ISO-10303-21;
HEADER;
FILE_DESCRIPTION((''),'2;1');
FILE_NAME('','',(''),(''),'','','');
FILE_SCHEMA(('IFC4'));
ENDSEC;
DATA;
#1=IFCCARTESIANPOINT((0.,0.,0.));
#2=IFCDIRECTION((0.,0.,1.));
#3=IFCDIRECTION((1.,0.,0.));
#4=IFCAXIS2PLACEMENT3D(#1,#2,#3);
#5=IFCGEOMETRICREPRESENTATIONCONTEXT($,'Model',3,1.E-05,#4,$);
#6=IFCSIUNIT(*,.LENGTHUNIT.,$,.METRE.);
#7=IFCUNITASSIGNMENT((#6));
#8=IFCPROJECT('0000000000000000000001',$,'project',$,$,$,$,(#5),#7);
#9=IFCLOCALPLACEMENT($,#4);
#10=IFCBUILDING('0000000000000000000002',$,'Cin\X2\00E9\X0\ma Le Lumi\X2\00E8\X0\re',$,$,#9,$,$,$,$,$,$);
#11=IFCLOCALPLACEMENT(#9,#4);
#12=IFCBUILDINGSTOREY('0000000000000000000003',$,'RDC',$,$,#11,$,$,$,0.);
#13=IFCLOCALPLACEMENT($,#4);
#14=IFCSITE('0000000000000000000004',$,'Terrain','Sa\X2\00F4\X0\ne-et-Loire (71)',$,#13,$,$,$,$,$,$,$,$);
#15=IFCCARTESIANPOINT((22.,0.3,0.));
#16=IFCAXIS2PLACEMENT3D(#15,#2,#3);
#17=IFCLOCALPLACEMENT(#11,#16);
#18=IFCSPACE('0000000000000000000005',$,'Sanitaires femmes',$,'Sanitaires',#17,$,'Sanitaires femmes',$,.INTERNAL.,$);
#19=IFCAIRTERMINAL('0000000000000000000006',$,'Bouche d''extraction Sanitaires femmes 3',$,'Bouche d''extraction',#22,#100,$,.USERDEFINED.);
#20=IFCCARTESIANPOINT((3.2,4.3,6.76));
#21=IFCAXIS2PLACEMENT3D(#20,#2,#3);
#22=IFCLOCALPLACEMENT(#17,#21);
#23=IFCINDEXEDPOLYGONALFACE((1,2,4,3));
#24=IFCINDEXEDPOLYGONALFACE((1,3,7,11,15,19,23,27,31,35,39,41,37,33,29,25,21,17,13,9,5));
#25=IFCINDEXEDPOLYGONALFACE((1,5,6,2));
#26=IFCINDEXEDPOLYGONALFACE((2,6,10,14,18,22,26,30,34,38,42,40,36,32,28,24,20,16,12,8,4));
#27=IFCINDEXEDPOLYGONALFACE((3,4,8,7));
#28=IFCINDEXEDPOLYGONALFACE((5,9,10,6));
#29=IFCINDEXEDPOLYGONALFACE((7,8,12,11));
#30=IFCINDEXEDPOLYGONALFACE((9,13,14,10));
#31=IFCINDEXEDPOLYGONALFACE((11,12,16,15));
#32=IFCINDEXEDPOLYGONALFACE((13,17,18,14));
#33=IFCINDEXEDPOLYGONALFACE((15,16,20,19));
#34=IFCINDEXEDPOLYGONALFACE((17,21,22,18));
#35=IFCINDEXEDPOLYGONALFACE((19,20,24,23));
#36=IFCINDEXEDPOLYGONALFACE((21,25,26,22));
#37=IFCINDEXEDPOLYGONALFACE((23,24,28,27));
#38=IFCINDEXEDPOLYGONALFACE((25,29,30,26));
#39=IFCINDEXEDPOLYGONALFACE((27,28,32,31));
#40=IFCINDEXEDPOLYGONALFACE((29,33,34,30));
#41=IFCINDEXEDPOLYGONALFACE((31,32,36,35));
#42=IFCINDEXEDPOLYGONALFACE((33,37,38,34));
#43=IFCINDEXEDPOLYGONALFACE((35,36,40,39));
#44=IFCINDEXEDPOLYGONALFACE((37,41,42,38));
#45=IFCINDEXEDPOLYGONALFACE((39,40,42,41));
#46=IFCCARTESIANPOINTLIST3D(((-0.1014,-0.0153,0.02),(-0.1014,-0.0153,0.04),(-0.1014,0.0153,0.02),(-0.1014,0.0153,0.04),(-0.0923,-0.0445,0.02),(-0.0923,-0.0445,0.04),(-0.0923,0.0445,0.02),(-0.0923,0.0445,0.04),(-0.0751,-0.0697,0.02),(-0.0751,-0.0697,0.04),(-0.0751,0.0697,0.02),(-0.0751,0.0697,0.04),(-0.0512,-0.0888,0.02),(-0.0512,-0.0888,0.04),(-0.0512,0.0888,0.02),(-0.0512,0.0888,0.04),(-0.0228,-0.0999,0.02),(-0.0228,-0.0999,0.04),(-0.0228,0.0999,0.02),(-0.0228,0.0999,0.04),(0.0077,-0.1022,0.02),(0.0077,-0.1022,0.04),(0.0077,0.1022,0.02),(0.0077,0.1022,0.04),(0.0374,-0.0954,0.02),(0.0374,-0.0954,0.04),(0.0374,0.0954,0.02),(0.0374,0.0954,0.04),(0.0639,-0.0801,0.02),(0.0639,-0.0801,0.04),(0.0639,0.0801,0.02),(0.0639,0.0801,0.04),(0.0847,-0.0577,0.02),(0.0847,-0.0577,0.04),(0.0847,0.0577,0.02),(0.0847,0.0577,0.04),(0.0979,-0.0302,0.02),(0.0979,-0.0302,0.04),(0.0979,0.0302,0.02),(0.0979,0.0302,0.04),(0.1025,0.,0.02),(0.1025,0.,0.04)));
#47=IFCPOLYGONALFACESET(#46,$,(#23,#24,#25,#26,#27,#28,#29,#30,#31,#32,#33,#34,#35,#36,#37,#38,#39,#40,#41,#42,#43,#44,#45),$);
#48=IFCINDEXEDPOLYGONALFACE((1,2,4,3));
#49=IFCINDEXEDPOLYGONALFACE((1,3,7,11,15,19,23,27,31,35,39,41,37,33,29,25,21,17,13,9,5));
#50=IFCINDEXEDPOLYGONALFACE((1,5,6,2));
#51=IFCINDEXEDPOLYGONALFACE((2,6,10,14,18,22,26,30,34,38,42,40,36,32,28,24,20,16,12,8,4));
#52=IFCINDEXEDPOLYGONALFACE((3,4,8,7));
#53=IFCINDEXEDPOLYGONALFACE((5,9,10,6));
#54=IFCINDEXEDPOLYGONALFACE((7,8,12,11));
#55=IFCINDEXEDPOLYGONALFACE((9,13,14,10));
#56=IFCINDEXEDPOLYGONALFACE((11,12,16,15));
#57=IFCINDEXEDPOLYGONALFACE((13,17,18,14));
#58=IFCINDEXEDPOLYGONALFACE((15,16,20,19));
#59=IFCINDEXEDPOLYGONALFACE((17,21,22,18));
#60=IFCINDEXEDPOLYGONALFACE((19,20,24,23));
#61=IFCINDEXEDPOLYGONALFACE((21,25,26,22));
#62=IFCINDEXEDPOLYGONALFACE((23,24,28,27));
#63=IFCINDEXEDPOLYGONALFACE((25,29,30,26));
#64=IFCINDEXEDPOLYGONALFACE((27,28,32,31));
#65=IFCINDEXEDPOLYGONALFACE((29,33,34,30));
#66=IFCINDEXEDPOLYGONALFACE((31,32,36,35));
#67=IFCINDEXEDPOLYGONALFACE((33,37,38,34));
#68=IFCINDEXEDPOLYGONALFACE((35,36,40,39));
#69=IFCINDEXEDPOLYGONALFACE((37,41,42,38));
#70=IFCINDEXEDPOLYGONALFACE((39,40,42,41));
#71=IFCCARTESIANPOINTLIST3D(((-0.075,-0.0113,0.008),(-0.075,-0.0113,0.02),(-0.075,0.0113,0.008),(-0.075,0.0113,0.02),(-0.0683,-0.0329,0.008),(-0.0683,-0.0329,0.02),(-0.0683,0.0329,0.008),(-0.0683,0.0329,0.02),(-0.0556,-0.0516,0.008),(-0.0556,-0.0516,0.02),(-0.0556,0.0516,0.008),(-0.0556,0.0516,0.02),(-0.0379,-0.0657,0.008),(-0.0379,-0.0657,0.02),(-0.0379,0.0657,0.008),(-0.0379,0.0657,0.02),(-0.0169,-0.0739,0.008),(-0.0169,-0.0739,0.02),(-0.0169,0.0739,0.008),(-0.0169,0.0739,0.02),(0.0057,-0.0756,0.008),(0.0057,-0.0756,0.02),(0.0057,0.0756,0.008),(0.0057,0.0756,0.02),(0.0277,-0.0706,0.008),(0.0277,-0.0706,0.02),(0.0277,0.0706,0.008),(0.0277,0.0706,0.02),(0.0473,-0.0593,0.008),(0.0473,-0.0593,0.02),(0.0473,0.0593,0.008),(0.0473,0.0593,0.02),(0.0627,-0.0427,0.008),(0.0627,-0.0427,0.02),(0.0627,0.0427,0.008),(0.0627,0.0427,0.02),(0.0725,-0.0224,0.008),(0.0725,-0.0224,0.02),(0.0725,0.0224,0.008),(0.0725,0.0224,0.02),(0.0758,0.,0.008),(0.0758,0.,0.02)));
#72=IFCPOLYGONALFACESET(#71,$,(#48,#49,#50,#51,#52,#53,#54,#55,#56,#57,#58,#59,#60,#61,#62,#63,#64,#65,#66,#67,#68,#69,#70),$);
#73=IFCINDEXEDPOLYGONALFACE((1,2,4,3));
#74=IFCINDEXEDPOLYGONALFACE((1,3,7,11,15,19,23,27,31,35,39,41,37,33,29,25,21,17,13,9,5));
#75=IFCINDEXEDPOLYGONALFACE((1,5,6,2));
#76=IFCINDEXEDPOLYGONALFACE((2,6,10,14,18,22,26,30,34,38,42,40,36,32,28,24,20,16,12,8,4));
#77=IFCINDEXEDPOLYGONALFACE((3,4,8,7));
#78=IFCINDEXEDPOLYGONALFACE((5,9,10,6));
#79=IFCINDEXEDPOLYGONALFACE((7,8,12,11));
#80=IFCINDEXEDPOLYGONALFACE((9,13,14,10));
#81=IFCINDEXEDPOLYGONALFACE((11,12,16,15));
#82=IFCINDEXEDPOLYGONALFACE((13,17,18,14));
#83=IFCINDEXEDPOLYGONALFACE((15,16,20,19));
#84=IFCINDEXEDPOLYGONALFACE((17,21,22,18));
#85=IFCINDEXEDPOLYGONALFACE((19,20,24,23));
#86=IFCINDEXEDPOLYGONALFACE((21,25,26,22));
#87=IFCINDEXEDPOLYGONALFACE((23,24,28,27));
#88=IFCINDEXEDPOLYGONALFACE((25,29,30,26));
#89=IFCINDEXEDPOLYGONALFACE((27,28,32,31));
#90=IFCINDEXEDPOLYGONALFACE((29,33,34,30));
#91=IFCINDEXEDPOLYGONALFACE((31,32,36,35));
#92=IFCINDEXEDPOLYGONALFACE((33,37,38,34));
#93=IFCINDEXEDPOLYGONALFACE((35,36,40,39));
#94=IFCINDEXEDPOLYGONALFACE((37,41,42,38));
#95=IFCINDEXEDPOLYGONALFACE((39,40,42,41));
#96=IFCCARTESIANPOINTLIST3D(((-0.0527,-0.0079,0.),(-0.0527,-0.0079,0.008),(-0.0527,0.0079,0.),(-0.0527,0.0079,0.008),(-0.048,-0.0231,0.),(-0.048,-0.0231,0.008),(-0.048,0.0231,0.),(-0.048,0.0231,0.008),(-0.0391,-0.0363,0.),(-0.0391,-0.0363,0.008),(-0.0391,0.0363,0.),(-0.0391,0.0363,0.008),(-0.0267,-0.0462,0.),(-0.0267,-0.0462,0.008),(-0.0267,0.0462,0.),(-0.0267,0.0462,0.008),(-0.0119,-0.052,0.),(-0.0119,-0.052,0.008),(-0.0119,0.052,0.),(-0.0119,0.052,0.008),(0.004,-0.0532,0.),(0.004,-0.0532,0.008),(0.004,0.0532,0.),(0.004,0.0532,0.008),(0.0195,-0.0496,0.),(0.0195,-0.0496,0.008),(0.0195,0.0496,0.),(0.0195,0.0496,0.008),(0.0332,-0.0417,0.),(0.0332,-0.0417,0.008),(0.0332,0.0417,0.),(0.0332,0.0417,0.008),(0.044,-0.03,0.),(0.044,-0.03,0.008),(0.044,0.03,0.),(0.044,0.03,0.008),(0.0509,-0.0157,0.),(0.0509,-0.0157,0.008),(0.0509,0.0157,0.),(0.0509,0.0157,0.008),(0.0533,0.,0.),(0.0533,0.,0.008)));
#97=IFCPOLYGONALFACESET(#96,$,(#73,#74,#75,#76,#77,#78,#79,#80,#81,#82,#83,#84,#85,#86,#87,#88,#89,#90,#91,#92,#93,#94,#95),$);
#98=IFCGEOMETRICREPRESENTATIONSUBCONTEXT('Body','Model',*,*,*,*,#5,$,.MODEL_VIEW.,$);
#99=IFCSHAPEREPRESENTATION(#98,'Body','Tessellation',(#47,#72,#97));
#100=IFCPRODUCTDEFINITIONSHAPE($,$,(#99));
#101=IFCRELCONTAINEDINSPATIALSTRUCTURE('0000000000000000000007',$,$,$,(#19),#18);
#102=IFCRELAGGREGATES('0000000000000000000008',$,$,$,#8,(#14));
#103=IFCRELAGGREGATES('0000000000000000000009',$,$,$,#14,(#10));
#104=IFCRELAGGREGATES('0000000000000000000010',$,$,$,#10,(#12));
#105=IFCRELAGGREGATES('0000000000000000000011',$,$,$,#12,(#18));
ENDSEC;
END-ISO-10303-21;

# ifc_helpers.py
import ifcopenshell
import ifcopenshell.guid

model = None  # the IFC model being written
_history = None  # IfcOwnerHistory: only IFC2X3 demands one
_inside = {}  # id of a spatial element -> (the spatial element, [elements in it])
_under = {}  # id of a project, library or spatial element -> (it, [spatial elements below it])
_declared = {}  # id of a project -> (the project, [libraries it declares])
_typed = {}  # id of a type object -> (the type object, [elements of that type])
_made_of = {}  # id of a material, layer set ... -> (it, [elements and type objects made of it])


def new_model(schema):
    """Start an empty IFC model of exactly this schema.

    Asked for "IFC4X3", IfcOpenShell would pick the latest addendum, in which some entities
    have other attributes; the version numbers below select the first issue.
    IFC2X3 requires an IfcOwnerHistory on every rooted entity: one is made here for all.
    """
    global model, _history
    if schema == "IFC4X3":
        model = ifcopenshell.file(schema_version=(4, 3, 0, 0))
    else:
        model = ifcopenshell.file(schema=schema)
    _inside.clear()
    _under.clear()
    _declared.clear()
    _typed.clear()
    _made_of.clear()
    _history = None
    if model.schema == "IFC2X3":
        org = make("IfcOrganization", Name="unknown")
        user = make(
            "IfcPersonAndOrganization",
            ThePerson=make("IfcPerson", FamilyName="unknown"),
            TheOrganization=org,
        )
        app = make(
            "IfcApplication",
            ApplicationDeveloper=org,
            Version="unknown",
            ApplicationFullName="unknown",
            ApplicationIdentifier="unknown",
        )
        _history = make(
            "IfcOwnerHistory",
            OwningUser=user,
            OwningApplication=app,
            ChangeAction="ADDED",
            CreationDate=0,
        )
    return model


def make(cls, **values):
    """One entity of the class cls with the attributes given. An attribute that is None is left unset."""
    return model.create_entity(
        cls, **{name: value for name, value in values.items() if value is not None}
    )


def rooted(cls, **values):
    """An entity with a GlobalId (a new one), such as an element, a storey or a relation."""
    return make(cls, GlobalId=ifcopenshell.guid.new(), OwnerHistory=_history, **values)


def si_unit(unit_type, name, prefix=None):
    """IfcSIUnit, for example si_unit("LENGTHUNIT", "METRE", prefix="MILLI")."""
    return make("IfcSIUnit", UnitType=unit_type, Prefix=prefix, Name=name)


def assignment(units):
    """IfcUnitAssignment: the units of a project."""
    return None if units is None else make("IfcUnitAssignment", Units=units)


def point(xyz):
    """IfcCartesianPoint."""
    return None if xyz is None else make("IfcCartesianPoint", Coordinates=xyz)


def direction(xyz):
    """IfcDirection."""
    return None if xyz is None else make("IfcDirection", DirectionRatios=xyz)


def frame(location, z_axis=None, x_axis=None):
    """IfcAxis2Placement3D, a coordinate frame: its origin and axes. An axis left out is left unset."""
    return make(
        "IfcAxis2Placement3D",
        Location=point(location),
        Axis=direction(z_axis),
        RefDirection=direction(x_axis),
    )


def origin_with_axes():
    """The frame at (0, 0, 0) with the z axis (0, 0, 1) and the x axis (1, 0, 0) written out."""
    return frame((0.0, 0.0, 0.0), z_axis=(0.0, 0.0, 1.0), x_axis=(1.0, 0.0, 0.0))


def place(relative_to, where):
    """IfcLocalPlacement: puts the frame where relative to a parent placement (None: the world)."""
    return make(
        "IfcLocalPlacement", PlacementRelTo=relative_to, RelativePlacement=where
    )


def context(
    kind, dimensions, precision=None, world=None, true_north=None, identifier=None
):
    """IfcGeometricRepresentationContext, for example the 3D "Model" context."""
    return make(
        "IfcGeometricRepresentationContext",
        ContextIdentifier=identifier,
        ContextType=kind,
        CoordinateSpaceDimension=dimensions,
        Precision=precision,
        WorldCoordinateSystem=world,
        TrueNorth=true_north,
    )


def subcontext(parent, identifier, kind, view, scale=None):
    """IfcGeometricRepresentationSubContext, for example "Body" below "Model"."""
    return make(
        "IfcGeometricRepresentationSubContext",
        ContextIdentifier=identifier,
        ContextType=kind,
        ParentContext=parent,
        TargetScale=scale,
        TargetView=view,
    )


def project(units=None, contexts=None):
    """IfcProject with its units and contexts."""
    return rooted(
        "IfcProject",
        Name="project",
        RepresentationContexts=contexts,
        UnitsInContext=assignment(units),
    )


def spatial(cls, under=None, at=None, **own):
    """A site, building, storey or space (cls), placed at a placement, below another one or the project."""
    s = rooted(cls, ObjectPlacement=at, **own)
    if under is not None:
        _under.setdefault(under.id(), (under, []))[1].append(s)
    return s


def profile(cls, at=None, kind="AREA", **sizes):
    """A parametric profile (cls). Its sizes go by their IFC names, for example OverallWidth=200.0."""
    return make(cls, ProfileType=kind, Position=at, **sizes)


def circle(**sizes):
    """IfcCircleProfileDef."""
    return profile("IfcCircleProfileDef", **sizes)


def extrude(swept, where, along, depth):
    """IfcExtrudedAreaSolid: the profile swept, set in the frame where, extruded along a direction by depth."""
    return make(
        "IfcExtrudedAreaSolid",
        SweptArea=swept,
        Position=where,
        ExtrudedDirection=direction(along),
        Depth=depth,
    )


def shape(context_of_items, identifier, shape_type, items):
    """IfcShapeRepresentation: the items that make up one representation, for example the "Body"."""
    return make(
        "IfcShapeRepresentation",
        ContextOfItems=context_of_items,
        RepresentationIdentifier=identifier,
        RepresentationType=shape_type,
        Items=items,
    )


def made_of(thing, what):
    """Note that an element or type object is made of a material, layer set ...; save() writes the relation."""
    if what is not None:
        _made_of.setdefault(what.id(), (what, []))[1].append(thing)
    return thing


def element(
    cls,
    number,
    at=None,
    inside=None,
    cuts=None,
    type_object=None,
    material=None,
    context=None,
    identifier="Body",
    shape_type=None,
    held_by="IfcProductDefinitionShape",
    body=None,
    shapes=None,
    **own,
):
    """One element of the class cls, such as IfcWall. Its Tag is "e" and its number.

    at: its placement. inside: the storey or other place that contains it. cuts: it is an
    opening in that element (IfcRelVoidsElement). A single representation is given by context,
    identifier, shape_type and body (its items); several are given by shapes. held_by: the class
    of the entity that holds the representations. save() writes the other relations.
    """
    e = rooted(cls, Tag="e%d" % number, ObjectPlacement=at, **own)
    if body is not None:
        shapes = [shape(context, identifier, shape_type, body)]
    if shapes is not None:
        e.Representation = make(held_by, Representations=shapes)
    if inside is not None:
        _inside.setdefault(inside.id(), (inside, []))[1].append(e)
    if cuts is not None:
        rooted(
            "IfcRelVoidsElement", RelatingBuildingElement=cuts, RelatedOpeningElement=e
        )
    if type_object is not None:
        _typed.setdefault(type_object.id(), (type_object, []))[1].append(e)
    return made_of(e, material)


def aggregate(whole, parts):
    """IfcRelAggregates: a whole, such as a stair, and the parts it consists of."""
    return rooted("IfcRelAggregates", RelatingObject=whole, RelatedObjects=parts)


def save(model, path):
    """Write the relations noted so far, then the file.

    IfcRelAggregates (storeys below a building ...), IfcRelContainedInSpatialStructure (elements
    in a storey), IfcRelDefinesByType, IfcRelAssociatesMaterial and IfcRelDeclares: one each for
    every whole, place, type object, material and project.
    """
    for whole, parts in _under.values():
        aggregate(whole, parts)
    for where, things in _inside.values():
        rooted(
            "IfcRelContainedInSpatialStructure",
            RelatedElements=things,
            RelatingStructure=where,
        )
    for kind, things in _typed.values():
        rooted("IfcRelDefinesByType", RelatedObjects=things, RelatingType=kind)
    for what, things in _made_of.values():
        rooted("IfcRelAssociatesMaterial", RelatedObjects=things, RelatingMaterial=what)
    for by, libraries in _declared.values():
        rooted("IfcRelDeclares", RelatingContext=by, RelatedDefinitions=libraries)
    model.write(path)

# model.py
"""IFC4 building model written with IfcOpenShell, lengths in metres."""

from ifc_helpers import new_model, si_unit, frame, origin_with_axes, place, context, subcontext, project, spatial, circle, extrude, element, save


model = new_model("IFC4")

# Units and contexts
model_context = context("Model", 3, precision=1e-05, world=origin_with_axes())
body_context = subcontext(model_context, "Body", "Model", "MODEL_VIEW")
ifc_project = project(units=[si_unit("LENGTHUNIT", "METRE")], contexts=[model_context])

# Site, building, storey
site_placement = place(None, origin_with_axes())
site = spatial("IfcSite", under=ifc_project, at=site_placement, Name="Terrain", Description="Saône-et-Loire (71)")
building_placement = place(None, origin_with_axes())
building = spatial("IfcBuilding", under=site, at=building_placement, Name="Cinéma Le Lumière")
storey_placement = place(building_placement, origin_with_axes())
storey = spatial("IfcBuildingStorey", under=building, at=storey_placement, Name="RDC", Elevation=0.0)

# Shared definitions
space_1_placement = place(storey_placement, frame((22.0, 0.3, 0.0), z_axis=(0.0, 0.0, 1.0), x_axis=(1.0, 0.0, 0.0)))
space_1 = spatial("IfcSpace", under=storey, at=space_1_placement, Name="Sanitaires femmes", ObjectType="Sanitaires", LongName="Sanitaires femmes", PredefinedType="INTERNAL")

# Air terminal
air_terminal_1_placement = place(space_1_placement, frame((3.2, 4.3, 6.76), z_axis=(0.0, 0.0, 1.0), x_axis=(1.0, 0.0, 0.0)))
element("IfcAirTerminal", 1, at=air_terminal_1_placement, inside=space_1, Name="Bouche d'extraction Sanitaires femmes 3", ObjectType="Bouche d'extraction", PredefinedType="USERDEFINED", context=body_context, shape_type="SweptSolid", body=[
    extrude(circle(Radius=0.1025), frame((0.0, 0.0, 0.02), z_axis=(0.0, 0.0, 1.0), x_axis=(1.0, 0.0, 0.0)), (0.0, 0.0, 1.0), 0.02),
    extrude(circle(Radius=0.0759), frame((0.0, 0.0, 0.008), z_axis=(0.0, 0.0, 1.0), x_axis=(1.0, 0.0, 0.0)), (0.0, 0.0, 1.0), 0.012),
    extrude(circle(Radius=0.0533), origin_with_axes(), (0.0, 0.0, 1.0), 0.008),
])

save(model, "model.ifc")
